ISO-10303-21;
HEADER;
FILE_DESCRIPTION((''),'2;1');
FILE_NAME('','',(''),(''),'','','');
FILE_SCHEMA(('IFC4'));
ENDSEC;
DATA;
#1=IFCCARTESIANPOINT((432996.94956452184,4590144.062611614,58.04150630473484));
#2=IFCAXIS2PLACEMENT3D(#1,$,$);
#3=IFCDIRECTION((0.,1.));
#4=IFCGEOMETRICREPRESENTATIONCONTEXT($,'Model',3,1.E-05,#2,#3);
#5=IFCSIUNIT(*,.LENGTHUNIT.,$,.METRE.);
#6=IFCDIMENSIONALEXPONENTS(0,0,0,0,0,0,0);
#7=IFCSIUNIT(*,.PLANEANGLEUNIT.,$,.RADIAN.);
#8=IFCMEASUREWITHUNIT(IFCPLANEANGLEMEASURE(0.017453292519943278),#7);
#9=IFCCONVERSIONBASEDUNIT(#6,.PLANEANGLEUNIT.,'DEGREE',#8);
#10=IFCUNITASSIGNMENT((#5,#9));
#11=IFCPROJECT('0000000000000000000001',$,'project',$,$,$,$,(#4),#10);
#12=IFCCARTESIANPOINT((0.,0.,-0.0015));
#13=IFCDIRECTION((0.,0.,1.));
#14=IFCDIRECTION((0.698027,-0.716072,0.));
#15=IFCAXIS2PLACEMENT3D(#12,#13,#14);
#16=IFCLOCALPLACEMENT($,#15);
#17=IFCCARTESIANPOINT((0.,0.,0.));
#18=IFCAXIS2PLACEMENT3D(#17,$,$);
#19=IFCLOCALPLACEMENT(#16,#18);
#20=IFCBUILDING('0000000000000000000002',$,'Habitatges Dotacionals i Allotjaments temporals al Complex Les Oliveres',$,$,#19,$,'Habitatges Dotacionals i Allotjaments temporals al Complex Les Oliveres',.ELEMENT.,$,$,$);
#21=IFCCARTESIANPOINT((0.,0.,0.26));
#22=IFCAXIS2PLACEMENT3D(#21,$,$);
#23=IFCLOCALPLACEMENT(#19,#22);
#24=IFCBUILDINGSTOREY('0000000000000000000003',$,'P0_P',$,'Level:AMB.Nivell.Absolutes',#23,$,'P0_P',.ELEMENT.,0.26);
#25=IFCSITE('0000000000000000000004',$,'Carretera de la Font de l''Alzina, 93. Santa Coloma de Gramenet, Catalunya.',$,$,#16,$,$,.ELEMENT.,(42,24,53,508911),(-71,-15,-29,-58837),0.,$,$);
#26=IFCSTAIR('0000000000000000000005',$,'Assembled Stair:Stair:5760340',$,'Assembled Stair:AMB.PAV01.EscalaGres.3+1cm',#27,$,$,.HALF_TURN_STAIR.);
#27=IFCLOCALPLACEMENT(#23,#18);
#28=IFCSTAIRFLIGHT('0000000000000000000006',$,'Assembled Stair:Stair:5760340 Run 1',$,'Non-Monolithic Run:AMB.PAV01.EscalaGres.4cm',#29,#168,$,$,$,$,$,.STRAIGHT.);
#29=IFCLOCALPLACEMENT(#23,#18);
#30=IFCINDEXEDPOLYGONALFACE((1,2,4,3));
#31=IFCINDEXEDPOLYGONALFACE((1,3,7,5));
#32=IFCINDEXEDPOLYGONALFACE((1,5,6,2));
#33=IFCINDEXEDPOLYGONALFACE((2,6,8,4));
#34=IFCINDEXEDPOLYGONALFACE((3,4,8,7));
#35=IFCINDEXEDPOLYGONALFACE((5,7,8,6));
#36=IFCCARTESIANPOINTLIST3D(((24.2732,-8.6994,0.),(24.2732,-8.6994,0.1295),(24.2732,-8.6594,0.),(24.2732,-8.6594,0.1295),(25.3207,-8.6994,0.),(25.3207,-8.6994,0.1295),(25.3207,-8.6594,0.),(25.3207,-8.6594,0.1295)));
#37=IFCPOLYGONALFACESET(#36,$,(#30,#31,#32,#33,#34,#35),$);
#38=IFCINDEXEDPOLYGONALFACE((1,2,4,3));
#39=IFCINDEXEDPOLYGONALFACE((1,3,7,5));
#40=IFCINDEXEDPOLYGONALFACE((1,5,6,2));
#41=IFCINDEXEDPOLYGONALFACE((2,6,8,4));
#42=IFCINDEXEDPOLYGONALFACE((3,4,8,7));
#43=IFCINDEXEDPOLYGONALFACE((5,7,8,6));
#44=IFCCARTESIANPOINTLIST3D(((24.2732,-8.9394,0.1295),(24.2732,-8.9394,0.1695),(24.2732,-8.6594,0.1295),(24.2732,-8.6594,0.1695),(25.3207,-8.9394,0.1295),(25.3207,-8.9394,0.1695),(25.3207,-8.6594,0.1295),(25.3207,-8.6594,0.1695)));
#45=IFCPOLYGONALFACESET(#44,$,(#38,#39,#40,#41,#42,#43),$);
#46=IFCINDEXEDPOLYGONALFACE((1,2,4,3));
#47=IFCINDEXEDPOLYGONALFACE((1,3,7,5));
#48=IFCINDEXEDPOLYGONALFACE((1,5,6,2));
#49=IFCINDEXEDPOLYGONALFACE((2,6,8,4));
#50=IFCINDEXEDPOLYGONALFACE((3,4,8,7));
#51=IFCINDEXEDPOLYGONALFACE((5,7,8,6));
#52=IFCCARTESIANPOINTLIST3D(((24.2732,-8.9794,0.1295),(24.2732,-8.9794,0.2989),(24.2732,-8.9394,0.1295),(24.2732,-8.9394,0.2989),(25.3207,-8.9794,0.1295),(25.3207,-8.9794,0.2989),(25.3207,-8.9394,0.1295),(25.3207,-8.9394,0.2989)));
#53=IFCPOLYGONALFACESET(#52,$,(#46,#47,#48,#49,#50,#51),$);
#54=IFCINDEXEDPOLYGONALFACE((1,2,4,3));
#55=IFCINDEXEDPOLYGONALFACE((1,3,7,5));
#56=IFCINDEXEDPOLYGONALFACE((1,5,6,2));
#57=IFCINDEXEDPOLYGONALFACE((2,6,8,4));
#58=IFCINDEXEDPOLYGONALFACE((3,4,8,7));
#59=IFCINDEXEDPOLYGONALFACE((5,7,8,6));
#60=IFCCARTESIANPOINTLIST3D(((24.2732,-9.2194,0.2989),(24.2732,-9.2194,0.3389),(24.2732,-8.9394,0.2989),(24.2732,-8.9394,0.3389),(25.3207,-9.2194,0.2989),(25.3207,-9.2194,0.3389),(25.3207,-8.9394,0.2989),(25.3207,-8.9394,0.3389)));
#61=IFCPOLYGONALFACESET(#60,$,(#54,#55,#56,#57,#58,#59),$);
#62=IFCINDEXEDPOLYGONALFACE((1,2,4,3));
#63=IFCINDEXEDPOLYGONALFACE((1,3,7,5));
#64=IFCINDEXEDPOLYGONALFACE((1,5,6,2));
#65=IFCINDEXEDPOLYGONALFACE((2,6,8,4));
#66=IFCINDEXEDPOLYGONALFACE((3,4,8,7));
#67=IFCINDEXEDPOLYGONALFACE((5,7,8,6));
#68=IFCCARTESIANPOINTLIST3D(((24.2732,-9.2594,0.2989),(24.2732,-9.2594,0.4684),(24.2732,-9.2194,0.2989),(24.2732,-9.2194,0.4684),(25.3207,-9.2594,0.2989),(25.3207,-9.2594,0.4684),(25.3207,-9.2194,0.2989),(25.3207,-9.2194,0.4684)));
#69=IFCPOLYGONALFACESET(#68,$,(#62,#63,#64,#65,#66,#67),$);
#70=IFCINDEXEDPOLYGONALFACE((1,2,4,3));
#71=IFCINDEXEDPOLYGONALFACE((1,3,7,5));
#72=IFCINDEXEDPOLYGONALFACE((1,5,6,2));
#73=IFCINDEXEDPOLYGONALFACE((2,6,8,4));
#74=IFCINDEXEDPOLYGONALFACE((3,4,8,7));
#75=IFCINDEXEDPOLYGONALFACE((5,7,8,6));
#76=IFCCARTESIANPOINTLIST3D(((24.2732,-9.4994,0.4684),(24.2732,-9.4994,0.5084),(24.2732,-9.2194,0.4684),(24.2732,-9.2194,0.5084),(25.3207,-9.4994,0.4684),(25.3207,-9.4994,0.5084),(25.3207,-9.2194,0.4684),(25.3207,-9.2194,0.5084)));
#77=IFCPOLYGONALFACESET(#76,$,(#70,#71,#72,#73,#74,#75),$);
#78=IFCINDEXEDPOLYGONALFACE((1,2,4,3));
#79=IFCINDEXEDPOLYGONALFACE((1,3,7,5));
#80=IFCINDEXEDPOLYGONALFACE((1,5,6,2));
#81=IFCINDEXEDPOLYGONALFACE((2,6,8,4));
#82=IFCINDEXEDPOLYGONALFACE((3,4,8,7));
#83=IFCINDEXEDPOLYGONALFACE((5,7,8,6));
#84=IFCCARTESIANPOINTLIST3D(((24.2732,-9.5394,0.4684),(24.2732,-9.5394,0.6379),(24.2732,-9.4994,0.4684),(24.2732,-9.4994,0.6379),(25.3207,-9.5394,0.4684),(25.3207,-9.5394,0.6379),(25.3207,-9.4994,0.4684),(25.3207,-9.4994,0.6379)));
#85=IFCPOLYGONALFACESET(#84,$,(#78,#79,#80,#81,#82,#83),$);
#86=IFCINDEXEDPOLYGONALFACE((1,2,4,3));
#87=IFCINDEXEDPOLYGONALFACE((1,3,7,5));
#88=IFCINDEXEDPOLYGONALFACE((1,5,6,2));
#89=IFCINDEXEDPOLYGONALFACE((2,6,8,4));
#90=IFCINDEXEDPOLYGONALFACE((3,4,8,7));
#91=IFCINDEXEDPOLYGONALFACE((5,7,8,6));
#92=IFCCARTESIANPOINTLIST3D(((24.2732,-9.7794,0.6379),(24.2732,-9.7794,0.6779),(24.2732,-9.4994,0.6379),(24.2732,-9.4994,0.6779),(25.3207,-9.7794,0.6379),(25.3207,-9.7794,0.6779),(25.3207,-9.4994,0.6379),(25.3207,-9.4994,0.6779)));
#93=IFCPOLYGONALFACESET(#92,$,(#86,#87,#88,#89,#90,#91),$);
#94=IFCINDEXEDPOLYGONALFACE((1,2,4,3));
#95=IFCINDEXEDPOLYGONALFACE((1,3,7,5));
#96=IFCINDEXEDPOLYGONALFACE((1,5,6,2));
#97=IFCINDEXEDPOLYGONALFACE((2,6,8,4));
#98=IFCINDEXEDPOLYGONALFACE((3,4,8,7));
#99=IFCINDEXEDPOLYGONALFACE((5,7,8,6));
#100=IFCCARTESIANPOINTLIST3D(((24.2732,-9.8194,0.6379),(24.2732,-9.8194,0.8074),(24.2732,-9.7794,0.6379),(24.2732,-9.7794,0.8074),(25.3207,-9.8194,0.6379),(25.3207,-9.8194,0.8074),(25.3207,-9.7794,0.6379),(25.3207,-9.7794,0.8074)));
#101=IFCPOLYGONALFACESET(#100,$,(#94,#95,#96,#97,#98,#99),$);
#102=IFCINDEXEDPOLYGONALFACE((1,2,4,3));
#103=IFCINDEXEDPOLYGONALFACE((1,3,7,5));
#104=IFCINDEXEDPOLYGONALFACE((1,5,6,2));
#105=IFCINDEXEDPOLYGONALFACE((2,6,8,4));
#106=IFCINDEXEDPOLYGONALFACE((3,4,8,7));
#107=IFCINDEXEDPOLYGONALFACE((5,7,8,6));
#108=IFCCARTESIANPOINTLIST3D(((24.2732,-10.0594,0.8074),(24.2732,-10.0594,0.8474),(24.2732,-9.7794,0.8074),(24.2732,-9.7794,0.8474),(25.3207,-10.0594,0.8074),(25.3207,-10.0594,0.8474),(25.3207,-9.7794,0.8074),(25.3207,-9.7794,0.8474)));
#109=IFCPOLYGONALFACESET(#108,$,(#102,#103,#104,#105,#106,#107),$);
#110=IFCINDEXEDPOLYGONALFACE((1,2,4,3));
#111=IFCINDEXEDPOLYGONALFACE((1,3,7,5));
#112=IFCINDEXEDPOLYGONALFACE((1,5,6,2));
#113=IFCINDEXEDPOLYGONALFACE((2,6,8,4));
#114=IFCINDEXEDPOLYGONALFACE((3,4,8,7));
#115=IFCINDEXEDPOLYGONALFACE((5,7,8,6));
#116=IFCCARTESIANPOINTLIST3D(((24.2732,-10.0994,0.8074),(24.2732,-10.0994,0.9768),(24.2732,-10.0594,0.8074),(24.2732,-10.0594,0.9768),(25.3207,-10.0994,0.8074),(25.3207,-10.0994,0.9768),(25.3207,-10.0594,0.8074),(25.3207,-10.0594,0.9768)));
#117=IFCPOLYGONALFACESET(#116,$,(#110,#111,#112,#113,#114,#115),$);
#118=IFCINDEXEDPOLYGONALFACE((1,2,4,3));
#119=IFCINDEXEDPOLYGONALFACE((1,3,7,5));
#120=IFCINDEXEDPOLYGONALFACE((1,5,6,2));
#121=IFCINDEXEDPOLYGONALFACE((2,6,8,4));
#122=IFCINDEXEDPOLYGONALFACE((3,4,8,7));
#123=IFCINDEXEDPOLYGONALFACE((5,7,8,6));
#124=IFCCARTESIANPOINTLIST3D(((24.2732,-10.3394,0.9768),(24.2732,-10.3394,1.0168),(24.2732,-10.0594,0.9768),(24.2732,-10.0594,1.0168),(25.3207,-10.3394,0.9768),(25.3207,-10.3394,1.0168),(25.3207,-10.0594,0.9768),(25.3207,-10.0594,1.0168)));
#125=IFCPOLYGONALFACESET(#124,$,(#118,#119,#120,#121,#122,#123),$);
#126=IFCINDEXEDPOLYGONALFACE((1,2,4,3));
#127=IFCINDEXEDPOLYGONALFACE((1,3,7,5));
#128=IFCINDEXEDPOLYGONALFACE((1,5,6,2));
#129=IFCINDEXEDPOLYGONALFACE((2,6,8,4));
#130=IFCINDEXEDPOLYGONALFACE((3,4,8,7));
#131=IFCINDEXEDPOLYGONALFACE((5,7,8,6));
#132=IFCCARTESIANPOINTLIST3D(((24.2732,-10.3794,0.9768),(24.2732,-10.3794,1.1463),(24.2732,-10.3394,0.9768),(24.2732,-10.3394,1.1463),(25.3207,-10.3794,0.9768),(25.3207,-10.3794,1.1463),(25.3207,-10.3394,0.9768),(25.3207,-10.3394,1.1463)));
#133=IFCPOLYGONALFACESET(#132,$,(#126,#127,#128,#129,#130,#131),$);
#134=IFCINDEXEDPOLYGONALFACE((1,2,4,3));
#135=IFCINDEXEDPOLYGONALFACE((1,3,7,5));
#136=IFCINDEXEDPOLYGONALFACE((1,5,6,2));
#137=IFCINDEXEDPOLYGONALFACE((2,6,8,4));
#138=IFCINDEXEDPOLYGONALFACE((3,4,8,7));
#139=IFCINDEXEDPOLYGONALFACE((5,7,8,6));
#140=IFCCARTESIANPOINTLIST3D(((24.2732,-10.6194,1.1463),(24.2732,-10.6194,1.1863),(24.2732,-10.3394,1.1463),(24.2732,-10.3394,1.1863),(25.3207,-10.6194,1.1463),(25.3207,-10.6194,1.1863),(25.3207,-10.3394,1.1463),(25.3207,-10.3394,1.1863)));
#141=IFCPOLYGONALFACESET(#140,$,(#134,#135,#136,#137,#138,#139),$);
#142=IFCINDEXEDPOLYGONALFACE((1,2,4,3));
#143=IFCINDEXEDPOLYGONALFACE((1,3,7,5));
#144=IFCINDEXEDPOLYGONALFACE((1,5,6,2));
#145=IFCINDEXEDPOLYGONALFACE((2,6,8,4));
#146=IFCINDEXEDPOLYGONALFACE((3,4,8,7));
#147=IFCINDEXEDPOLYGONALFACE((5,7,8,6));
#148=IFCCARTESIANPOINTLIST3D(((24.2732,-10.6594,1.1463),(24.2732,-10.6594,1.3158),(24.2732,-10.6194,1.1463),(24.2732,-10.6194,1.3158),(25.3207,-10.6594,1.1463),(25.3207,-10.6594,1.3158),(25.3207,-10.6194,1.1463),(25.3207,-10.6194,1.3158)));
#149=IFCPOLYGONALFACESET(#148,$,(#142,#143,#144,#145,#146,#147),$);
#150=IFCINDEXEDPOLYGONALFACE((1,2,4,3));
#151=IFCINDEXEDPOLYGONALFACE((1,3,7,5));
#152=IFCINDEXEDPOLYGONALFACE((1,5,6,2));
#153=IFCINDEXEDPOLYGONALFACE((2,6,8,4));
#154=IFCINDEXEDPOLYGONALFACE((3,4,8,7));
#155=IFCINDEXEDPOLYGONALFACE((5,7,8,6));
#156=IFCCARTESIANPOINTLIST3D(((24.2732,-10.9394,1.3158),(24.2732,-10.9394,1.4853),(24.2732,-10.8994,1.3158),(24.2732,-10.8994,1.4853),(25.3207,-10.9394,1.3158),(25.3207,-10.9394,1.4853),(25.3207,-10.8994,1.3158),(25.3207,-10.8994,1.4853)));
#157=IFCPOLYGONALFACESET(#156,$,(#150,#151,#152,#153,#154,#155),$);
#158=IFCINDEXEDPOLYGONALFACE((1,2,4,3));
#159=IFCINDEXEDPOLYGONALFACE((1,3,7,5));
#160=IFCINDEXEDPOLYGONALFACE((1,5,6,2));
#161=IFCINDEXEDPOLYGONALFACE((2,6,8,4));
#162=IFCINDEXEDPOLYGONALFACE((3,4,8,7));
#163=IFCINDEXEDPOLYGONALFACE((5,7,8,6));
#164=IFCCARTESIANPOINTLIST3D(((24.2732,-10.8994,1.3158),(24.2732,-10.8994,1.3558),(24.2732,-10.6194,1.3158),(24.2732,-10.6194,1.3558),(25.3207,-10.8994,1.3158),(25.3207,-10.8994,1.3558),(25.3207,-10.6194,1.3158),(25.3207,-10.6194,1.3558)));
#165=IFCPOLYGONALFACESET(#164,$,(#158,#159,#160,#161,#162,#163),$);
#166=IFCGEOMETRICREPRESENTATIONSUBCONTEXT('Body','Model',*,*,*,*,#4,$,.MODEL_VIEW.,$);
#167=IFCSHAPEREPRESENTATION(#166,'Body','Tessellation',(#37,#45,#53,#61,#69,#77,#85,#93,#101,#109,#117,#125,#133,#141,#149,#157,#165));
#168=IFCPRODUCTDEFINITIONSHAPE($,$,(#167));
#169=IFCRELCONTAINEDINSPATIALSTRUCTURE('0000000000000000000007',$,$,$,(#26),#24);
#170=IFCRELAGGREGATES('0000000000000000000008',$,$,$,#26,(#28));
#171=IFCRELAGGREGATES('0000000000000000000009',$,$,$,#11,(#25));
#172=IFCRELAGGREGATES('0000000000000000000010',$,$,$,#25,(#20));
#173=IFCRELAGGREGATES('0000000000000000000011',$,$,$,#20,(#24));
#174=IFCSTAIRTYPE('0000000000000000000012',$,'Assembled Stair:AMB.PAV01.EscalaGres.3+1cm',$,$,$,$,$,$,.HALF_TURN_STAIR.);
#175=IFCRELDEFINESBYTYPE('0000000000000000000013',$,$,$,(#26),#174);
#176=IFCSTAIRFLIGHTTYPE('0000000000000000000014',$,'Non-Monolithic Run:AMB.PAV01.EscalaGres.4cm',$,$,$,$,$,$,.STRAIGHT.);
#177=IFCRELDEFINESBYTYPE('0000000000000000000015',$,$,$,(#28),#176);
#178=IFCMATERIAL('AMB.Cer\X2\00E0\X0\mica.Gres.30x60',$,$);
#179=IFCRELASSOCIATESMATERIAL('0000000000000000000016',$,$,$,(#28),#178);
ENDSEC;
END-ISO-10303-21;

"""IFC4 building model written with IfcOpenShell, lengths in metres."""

from ifc_helpers import new_model, entity, si_unit, converted_unit, direction, frame, origin, place, context, subcontext, project, spatial, indexed_curve, outline, extrude, material, type_object, element, aggregate, save


model = new_model("IFC4")

# Units and contexts
model_context = context("Model", 3, precision=1e-05, world=frame((432996.94956452184, 4590144.062611614, 58.04150630473484)), true_north=direction((0.0, 1.0)))
body_context = subcontext(model_context, "Body", "Model", "MODEL_VIEW")
ifc_project = project(units=[si_unit("LENGTHUNIT", "METRE"), converted_unit("PLANEANGLEUNIT", "DEGREE", entity("IfcPlaneAngleMeasure", 0.017453292519943278), si_unit("PLANEANGLEUNIT", "RADIAN"), dimensions=[0, 0, 0, 0, 0, 0, 0])], contexts=[model_context])

# Site, building, storey
site_placement = place(None, frame((0.0, 0.0, -0.0015), z_axis=(0.0, 0.0, 1.0), x_axis=(0.698027, -0.716072, 0.0)))
site = spatial("IfcSite", under=ifc_project, at=site_placement, Name="Carretera de la Font de l'Alzina, 93. Santa Coloma de Gramenet, Catalunya.", CompositionType="ELEMENT", RefLatitude=(42, 24, 53, 508911), RefLongitude=(-71, -15, -29, -58837), RefElevation=0.0)
building_placement = place(site_placement, origin())
building = spatial("IfcBuilding", under=site, at=building_placement, Name="Habitatges Dotacionals i Allotjaments temporals al Complex Les Oliveres", LongName="Habitatges Dotacionals i Allotjaments temporals al Complex Les Oliveres", CompositionType="ELEMENT")
storey_placement = place(building_placement, frame((0.0, 0.0, 0.26)))
storey = spatial("IfcBuildingStorey", under=building, at=storey_placement, Name="P0_P", ObjectType="Level:AMB.Nivell.Absolutes", LongName="P0_P", CompositionType="ELEMENT", Elevation=0.26)

# Stair
stair_type_1 = type_object("IfcStairType", Name="Assembled Stair:AMB.PAV01.EscalaGres.3+1cm", PredefinedType="HALF_TURN_STAIR")
stair_1_placement = place(storey_placement, origin())
stair_1 = element("IfcStair", 1, at=stair_1_placement, inside=storey, type_object=stair_type_1, Name="Assembled Stair:Stair:5760340", ObjectType="Assembled Stair:AMB.PAV01.EscalaGres.3+1cm", PredefinedType="HALF_TURN_STAIR")
ifc_material_1 = material(Name="AMB.Ceràmica.Gres.30x60")

# Shared definitions
stair_flight_type = type_object("IfcStairFlightType", Name="Non-Monolithic Run:AMB.PAV01.EscalaGres.4cm", PredefinedType="STRAIGHT")

# Stair flight
stair_flight_1_placement = place(stair_1_placement, origin())
stair_flight_1 = element("IfcStairFlight", 2, at=stair_flight_1_placement, type_object=stair_flight_type, material=ifc_material_1, Name="Assembled Stair:Stair:5760340 Run 1", ObjectType="Non-Monolithic Run:AMB.PAV01.EscalaGres.4cm", PredefinedType="STRAIGHT", context=body_context, shape_type="SweptSolid", body=[
    extrude(outline(indexed_curve([(-0.5238, -0.02), (0.5238, -0.02), (0.5238, 0.02), (-0.5238, 0.02), (-0.5238, -0.02)], self_intersect=False)), frame((24.7969, -8.6794, 0.0)), (0.0, 0.0, 1.0), 0.1295),
    extrude(outline(indexed_curve([(-0.14, -0.5238), (0.14, -0.5238), (0.14, 0.5238), (-0.14, 0.5238), (-0.14, -0.5238)], self_intersect=False)), frame((24.7969, -8.7994, 0.1295), z_axis=(0.0, 0.0, 1.0), x_axis=(0.0, 1.0, 0.0)), (0.0, 0.0, 1.0), 0.04),
    extrude(outline(indexed_curve([(-0.5238, -0.02), (0.5238, -0.02), (0.5238, 0.02), (-0.5238, 0.02), (-0.5238, -0.02)], self_intersect=False)), frame((24.7969, -8.9594, 0.1295)), (0.0, 0.0, 1.0), 0.1695),
    extrude(outline(indexed_curve([(-0.14, -0.5238), (0.14, -0.5238), (0.14, 0.5238), (-0.14, 0.5238), (-0.14, -0.5238)], self_intersect=False)), frame((24.7969, -9.0794, 0.2989), z_axis=(0.0, 0.0, 1.0), x_axis=(0.0, 1.0, 0.0)), (0.0, 0.0, 1.0), 0.04),
    extrude(outline(indexed_curve([(-0.5238, -0.02), (0.5238, -0.02), (0.5238, 0.02), (-0.5238, 0.02), (-0.5238, -0.02)], self_intersect=False)), frame((24.7969, -9.2394, 0.2989)), (0.0, 0.0, 1.0), 0.1695),
    extrude(outline(indexed_curve([(-0.14, -0.5238), (0.14, -0.5238), (0.14, 0.5238), (-0.14, 0.5238), (-0.14, -0.5238)], self_intersect=False)), frame((24.7969, -9.3594, 0.4684), z_axis=(0.0, 0.0, 1.0), x_axis=(0.0, 1.0, 0.0)), (0.0, 0.0, 1.0), 0.04),
    extrude(outline(indexed_curve([(-0.5238, -0.02), (0.5238, -0.02), (0.5238, 0.02), (-0.5238, 0.02), (-0.5238, -0.02)], self_intersect=False)), frame((24.7969, -9.5194, 0.4684)), (0.0, 0.0, 1.0), 0.1695),
    extrude(outline(indexed_curve([(-0.14, -0.5238), (0.14, -0.5238), (0.14, 0.5238), (-0.14, 0.5238), (-0.14, -0.5238)], self_intersect=False)), frame((24.7969, -9.6394, 0.6379), z_axis=(0.0, 0.0, 1.0), x_axis=(0.0, 1.0, 0.0)), (0.0, 0.0, 1.0), 0.04),
    extrude(outline(indexed_curve([(-0.5238, -0.02), (0.5238, -0.02), (0.5238, 0.02), (-0.5238, 0.02), (-0.5238, -0.02)], self_intersect=False)), frame((24.7969, -9.7994, 0.6379)), (0.0, 0.0, 1.0), 0.1695),
    extrude(outline(indexed_curve([(-0.14, -0.5238), (0.14, -0.5238), (0.14, 0.5238), (-0.14, 0.5238), (-0.14, -0.5238)], self_intersect=False)), frame((24.7969, -9.9194, 0.8074), z_axis=(0.0, 0.0, 1.0), x_axis=(0.0, 1.0, 0.0)), (0.0, 0.0, 1.0), 0.04),
    extrude(outline(indexed_curve([(-0.5238, -0.02), (0.5238, -0.02), (0.5238, 0.02), (-0.5238, 0.02), (-0.5238, -0.02)], self_intersect=False)), frame((24.7969, -10.0794, 0.8074)), (0.0, 0.0, 1.0), 0.1695),
    extrude(outline(indexed_curve([(-0.14, -0.5238), (0.14, -0.5238), (0.14, 0.5238), (-0.14, 0.5238), (-0.14, -0.5238)], self_intersect=False)), frame((24.7969, -10.1994, 0.9768), z_axis=(0.0, 0.0, 1.0), x_axis=(0.0, 1.0, 0.0)), (0.0, 0.0, 1.0), 0.04),
    extrude(outline(indexed_curve([(-0.5238, -0.02), (0.5238, -0.02), (0.5238, 0.02), (-0.5238, 0.02), (-0.5238, -0.02)], self_intersect=False)), frame((24.7969, -10.3594, 0.9768)), (0.0, 0.0, 1.0), 0.1695),
    extrude(outline(indexed_curve([(-0.14, -0.5238), (0.14, -0.5238), (0.14, 0.5238), (-0.14, 0.5238), (-0.14, -0.5238)], self_intersect=False)), frame((24.7969, -10.4794, 1.1463), z_axis=(0.0, 0.0, 1.0), x_axis=(0.0, 1.0, 0.0)), (0.0, 0.0, 1.0), 0.04),
    extrude(outline(indexed_curve([(-0.5238, -0.02), (0.5238, -0.02), (0.5238, 0.02), (-0.5238, 0.02), (-0.5238, -0.02)], self_intersect=False)), frame((24.7969, -10.6394, 1.1463)), (0.0, 0.0, 1.0), 0.1695),
    extrude(outline(indexed_curve([(-0.5238, -0.02), (0.5238, -0.02), (0.5238, 0.02), (-0.5238, 0.02), (-0.5238, -0.02)], self_intersect=False)), frame((24.7969, -10.9194, 1.3158)), (0.0, 0.0, 1.0), 0.1695),
    extrude(outline(indexed_curve([(-0.14, -0.5238), (0.14, -0.5238), (0.14, 0.5238), (-0.14, 0.5238), (-0.14, -0.5238)], self_intersect=False)), frame((24.7969, -10.7594, 1.3158), z_axis=(0.0, 0.0, 1.0), x_axis=(0.0, 1.0, 0.0)), (0.0, 0.0, 1.0), 0.04),
])
aggregate(stair_1, [stair_flight_1])

save(model, "model.ifc")
